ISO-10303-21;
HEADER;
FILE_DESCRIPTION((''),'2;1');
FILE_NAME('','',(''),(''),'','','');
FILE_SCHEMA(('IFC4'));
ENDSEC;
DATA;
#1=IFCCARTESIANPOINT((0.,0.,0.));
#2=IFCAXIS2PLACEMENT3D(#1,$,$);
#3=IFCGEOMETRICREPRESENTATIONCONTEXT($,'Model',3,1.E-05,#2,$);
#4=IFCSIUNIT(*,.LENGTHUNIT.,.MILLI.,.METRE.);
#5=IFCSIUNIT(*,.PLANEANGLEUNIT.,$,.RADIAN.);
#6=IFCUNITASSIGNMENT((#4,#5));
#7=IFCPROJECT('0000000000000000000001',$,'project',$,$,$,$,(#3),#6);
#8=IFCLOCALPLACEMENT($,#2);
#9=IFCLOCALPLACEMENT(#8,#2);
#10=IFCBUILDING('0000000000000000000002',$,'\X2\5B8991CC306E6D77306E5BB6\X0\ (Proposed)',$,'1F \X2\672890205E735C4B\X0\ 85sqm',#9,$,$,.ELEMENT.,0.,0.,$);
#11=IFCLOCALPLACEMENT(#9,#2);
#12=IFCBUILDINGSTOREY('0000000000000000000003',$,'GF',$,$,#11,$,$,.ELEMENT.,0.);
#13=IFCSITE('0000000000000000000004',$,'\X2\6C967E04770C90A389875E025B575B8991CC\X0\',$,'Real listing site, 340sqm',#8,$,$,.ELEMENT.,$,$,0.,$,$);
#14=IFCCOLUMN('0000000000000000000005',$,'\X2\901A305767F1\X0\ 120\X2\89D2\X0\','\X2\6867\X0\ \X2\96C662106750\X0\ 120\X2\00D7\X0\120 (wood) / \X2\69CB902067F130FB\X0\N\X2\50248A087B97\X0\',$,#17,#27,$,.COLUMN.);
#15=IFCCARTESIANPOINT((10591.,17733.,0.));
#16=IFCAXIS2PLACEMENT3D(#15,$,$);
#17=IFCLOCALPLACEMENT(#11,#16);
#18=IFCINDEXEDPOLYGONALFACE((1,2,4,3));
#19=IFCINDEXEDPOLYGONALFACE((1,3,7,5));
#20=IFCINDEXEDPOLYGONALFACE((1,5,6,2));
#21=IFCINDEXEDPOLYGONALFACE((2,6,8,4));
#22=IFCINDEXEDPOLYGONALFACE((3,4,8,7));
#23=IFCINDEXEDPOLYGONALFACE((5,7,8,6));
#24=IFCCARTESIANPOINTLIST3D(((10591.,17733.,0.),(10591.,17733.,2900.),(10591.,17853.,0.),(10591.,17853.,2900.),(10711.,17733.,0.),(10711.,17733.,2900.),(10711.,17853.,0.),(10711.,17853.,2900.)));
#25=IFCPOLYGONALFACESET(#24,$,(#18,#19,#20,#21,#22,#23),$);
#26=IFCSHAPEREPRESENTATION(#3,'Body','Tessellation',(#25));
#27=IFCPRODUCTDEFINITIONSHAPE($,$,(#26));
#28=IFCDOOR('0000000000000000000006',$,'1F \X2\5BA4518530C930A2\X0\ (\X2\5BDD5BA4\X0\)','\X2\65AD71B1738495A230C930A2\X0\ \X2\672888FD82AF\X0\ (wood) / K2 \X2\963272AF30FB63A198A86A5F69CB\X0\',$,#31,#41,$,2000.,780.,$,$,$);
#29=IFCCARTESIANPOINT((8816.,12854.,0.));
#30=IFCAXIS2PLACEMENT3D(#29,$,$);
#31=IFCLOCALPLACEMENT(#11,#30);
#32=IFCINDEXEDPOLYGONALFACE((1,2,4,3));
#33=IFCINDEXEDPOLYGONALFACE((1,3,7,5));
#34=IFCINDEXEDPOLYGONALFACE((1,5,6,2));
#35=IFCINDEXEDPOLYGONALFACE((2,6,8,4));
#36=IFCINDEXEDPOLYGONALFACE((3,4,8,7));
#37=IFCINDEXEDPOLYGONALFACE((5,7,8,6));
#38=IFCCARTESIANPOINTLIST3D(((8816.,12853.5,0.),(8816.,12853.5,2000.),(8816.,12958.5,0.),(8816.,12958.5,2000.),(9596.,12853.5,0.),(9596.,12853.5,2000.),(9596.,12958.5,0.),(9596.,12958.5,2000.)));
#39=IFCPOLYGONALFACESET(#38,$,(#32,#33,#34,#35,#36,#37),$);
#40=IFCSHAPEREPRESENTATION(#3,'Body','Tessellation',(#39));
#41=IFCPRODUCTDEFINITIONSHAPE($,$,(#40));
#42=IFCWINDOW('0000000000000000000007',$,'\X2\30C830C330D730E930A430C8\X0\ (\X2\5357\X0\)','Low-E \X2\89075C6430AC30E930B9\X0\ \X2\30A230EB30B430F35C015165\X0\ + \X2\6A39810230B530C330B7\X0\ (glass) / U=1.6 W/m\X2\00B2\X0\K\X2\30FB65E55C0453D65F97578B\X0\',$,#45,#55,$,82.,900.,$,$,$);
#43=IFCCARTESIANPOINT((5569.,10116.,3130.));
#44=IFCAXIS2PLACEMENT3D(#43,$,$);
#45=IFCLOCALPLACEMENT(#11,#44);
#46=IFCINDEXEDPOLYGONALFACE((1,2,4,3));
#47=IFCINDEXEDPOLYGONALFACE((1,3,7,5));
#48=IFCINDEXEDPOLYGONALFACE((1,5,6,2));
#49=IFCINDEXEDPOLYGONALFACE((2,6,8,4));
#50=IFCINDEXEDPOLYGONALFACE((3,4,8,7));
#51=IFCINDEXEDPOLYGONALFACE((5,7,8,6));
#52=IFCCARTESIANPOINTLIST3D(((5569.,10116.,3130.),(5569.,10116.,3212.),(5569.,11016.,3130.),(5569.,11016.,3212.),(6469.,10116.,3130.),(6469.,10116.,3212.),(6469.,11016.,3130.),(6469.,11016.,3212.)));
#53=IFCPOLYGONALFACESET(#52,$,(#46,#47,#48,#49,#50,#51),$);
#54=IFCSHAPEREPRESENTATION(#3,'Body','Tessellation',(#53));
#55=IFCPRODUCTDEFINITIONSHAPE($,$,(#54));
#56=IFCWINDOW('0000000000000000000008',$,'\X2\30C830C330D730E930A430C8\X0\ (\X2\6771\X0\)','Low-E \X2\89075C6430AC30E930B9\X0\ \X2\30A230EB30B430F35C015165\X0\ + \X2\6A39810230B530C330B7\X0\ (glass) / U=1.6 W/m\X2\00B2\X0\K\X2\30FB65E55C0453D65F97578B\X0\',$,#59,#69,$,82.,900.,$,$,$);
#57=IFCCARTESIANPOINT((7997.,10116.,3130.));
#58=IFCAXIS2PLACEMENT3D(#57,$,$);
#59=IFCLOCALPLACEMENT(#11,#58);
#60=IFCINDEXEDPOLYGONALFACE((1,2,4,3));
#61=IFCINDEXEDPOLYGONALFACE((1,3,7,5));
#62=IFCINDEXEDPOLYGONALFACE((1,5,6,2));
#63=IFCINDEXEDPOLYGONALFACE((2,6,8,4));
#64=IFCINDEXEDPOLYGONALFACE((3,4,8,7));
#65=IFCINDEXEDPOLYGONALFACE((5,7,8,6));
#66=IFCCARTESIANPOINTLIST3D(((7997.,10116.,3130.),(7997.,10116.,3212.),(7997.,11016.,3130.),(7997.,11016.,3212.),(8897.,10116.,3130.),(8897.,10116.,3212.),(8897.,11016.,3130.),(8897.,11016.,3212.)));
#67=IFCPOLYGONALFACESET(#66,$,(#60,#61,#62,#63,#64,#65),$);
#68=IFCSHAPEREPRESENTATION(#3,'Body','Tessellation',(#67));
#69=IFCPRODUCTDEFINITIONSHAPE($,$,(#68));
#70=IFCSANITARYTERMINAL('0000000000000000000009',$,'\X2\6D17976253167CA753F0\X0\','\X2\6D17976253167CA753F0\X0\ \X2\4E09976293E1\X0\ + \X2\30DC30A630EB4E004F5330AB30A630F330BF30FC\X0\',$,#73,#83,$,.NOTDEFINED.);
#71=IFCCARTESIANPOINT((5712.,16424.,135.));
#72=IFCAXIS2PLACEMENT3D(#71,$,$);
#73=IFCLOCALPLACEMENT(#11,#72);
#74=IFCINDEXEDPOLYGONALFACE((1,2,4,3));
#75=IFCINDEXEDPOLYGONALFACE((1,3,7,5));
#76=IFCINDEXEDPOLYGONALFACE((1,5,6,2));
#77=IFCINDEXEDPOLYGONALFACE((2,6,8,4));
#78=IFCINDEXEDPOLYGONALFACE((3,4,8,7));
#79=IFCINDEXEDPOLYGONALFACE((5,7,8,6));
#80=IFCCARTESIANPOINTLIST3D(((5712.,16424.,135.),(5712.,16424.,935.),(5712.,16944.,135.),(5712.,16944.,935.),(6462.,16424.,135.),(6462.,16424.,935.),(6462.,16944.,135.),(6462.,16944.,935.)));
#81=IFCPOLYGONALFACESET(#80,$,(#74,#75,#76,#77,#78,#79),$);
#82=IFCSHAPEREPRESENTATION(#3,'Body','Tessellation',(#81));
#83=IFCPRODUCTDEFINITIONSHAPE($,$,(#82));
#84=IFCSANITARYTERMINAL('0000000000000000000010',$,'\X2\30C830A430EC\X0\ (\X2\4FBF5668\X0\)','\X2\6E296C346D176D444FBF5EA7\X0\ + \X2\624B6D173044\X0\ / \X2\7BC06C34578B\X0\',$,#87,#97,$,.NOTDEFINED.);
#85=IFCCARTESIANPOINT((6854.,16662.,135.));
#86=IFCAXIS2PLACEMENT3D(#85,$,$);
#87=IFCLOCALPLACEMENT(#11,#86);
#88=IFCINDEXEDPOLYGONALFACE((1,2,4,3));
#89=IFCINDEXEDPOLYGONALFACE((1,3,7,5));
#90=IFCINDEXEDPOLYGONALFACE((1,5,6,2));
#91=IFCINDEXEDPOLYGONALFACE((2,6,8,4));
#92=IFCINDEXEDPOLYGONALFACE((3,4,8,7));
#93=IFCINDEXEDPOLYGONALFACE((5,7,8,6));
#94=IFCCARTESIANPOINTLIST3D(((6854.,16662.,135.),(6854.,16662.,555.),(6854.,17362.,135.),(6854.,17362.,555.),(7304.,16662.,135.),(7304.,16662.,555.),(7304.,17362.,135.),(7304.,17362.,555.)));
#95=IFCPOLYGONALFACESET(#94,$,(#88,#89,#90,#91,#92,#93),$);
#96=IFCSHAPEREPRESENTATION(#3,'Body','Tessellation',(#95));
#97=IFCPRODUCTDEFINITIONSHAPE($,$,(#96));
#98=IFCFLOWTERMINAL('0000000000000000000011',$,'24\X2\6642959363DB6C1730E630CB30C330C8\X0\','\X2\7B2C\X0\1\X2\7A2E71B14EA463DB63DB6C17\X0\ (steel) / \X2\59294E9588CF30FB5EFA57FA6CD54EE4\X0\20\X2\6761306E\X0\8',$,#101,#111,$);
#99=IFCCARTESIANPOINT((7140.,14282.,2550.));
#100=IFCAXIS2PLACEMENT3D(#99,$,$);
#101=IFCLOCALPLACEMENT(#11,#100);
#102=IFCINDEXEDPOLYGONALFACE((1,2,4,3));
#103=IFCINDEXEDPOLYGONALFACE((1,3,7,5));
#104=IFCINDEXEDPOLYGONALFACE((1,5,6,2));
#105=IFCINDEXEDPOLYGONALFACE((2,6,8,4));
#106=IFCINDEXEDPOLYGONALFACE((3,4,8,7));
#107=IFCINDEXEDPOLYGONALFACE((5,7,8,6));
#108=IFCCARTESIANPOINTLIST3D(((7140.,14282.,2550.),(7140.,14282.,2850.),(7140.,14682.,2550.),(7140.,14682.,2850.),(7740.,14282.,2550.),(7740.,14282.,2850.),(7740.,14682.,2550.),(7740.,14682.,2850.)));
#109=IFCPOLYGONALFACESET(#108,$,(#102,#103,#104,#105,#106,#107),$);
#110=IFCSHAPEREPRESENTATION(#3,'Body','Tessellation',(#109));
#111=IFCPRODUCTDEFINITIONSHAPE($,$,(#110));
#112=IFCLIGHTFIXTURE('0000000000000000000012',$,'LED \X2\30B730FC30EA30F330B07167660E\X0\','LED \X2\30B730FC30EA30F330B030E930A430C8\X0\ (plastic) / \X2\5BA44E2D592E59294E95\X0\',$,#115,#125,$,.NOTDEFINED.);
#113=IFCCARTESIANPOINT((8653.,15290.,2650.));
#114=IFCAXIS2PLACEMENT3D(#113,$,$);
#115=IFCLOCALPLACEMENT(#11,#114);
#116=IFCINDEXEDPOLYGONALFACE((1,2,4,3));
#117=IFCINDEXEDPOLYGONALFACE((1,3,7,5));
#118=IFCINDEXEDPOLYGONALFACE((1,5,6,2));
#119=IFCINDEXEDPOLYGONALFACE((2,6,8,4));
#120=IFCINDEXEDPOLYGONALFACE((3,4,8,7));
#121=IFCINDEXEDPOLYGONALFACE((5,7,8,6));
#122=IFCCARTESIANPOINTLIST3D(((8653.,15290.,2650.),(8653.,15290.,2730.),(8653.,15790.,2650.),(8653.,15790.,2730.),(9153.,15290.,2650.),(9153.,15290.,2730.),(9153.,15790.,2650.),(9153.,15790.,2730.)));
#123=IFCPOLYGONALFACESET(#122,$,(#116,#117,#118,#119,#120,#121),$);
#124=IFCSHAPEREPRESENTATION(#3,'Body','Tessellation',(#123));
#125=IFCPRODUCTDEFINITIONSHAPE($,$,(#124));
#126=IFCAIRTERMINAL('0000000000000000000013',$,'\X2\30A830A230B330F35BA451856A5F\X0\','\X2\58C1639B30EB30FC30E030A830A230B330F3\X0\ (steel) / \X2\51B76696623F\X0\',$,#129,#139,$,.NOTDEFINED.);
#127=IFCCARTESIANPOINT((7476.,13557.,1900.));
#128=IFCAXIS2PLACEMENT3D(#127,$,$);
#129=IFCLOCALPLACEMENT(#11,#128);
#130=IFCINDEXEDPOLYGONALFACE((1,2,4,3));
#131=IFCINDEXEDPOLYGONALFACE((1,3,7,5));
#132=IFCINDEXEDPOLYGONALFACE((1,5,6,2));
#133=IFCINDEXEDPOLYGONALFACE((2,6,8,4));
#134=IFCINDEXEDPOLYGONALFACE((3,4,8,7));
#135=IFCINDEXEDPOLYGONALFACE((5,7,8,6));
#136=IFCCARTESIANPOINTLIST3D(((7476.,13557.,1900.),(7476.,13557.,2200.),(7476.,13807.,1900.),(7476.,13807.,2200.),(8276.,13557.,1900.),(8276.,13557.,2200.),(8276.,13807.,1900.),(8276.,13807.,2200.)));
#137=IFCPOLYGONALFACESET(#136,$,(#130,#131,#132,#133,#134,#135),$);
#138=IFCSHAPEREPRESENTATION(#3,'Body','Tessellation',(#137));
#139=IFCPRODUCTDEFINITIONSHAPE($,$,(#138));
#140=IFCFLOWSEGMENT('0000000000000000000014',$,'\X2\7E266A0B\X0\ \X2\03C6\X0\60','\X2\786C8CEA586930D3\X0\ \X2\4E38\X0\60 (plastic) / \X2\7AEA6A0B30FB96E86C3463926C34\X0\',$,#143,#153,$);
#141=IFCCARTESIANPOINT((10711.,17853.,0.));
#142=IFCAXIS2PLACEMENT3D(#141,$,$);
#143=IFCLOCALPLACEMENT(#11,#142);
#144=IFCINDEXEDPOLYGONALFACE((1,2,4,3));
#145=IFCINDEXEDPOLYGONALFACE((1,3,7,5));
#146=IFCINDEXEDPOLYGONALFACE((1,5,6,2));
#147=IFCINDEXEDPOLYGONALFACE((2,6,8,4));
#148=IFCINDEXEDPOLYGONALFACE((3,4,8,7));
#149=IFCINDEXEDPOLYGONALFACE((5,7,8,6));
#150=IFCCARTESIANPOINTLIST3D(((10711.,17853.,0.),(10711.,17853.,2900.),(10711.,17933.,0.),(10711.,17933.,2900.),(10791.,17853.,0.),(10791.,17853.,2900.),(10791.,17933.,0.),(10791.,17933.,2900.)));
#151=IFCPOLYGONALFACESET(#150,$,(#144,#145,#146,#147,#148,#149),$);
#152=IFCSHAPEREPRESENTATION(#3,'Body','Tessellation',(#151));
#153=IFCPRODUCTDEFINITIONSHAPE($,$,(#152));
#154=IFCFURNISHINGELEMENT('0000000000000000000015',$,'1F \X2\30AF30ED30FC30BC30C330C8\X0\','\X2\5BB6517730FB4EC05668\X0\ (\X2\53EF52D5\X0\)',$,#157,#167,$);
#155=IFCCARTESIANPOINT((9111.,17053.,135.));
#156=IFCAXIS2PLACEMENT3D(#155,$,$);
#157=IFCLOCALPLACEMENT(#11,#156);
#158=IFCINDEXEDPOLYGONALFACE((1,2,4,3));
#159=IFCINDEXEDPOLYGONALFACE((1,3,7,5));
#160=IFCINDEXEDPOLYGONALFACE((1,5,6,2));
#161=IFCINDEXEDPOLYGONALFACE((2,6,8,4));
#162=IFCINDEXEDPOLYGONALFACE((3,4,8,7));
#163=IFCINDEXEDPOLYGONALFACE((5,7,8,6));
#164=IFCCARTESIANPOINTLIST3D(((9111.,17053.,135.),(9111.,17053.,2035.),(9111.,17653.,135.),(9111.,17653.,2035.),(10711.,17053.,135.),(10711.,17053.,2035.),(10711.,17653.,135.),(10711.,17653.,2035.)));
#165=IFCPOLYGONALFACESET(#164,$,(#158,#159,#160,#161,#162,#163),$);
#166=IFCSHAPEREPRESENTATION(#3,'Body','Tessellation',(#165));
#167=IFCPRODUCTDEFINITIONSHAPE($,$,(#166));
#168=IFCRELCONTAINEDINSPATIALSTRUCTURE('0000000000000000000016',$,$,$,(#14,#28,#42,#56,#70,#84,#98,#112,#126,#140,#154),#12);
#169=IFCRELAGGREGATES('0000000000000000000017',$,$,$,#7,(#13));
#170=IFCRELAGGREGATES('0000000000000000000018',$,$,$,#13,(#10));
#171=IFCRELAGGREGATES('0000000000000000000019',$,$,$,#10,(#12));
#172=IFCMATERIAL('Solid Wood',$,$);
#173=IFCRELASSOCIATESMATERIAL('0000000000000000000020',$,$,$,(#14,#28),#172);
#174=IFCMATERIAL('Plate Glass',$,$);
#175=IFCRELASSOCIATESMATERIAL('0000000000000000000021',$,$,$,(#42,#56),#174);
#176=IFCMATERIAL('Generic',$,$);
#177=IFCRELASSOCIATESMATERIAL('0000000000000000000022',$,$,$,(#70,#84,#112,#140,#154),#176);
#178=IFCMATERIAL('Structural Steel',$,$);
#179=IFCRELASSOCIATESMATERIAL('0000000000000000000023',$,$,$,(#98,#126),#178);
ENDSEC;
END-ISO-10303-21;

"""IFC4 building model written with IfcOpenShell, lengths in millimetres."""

from ifc_helpers import new_model, si_unit, frame, frame_2d, origin, place, context, project, spatial, rectangle, extrude, material, element, save


model = new_model("IFC4")

# Units and contexts
model_context = context("Model", 3, precision=1e-05, world=origin())
ifc_project = project(units=[si_unit("LENGTHUNIT", "METRE", prefix="MILLI"), si_unit("PLANEANGLEUNIT", "RADIAN")], contexts=[model_context])

# Site, building, storey
site_placement = place(None, origin())
site = spatial("IfcSite", under=ifc_project, at=site_placement, Name="沖縄県那覇市字安里", ObjectType="Real listing site, 340sqm", CompositionType="ELEMENT", RefElevation=0.0)
building_placement = place(site_placement, origin())
building = spatial("IfcBuilding", under=site, at=building_placement, Name="安里の海の家 (Proposed)", ObjectType="1F 木造平屋 85sqm", CompositionType="ELEMENT", ElevationOfRefHeight=0.0, ElevationOfTerrain=0.0)
storey_placement = place(building_placement, origin())
storey = spatial("IfcBuildingStorey", under=building, at=storey_placement, Name="GF", CompositionType="ELEMENT", Elevation=0.0)

# Column
ifc_material_1 = material(Name="Solid Wood")
column_1_placement = place(storey_placement, frame((10591.0, 17733.0, 0.0)))
element("IfcColumn", 1, at=column_1_placement, inside=storey, material=ifc_material_1, Name="通し柱 120角", Description="桧 集成材 120×120 (wood) / 構造柱・N値計算", PredefinedType="COLUMN", context=model_context, shape_type="SweptSolid", body=[
    extrude(rectangle(XDim=120.0, YDim=120.0, at=frame_2d((60.0, 60.0))), frame((10591.0, 17733.0, 0.0)), (0.0, 0.0, 1.0), 2900.0),
])

# Door
door_placement = place(storey_placement, frame((8816.0, 12854.0, 0.0)))
element("IfcDoor", 2, at=door_placement, inside=storey, material=ifc_material_1, Name="1F 室内ドア (寝室)", Description="断熱玄関ドア 木製芯 (wood) / K2 防犯・採風機構", OverallHeight=2000.0, OverallWidth=780.0, context=model_context, shape_type="SweptSolid", body=[
    extrude(rectangle(XDim=780.0, YDim=105.0, at=frame_2d((390.0, 52.0))), frame((8816.0, 12854.0, 0.0)), (0.0, 0.0, 1.0), 2000.0),
])

# Windows
ifc_material_2 = material(Name="Plate Glass")
window_1_placement = place(storey_placement, frame((5569.0, 10116.0, 3130.0)))
element("IfcWindow", 3, at=window_1_placement, inside=storey, material=ifc_material_2, Name="トップライト (南)", Description="Low-E 複層ガラス アルゴン封入 + 樹脂サッシ (glass) / U=1.6 W/m²K・日射取得型", OverallHeight=82.0, OverallWidth=900.0, context=model_context, shape_type="SweptSolid", body=[
    extrude(rectangle(XDim=900.0, YDim=900.0, at=frame_2d((450.0, 450.0))), frame((5569.0, 10116.0, 3130.0)), (0.0, 0.0, 1.0), 82.0),
])
window_2_placement = place(storey_placement, frame((7997.0, 10116.0, 3130.0)))
element("IfcWindow", 4, at=window_2_placement, inside=storey, material=ifc_material_2, Name="トップライト (東)", Description="Low-E 複層ガラス アルゴン封入 + 樹脂サッシ (glass) / U=1.6 W/m²K・日射取得型", OverallHeight=82.0, OverallWidth=900.0, context=model_context, shape_type="SweptSolid", body=[
    extrude(rectangle(XDim=900.0, YDim=900.0, at=frame_2d((450.0, 450.0))), frame((7997.0, 10116.0, 3130.0)), (0.0, 0.0, 1.0), 82.0),
])

# Sanitary terminals
ifc_material_3 = material(Name="Generic")
sanitary_terminal_1_placement = place(storey_placement, frame((5712.0, 16424.0, 135.0)))
element("IfcSanitaryTerminal", 5, at=sanitary_terminal_1_placement, inside=storey, material=ifc_material_3, Name="洗面化粧台", Description="洗面化粧台 三面鏡 + ボウル一体カウンター", PredefinedType="NOTDEFINED", context=model_context, shape_type="SweptSolid", body=[
    extrude(rectangle(XDim=750.0, YDim=520.0, at=frame_2d((375.0, 260.0))), frame((5712.0, 16424.0, 135.0)), (0.0, 0.0, 1.0), 800.0),
])
sanitary_terminal_2_placement = place(storey_placement, frame((6854.0, 16662.0, 135.0)))
element("IfcSanitaryTerminal", 6, at=sanitary_terminal_2_placement, inside=storey, material=ifc_material_3, Name="トイレ (便器)", Description="温水洗浄便座 + 手洗い / 節水型", PredefinedType="NOTDEFINED", context=model_context, shape_type="SweptSolid", body=[
    extrude(rectangle(XDim=450.0, YDim=700.0, at=frame_2d((225.0, 350.0))), frame((6854.0, 16662.0, 135.0)), (0.0, 0.0, 1.0), 420.0),
])

# Flow terminal
ifc_material_4 = material(Name="Structural Steel")
flow_terminal_placement = place(storey_placement, frame((7140.0, 14282.0, 2550.0)))
element("IfcFlowTerminal", 7, at=flow_terminal_placement, inside=storey, material=ifc_material_4, Name="24時間換気ユニット", Description="第1種熱交換換気 (steel) / 天井裏・建基法令20条の8", context=model_context, shape_type="SweptSolid", body=[
    extrude(rectangle(XDim=600.0, YDim=400.0, at=frame_2d((300.0, 200.0))), frame((7140.0, 14282.0, 2550.0)), (0.0, 0.0, 1.0), 300.0),
])

# Light fixture
light_fixture_placement = place(storey_placement, frame((8653.0, 15290.0, 2650.0)))
element("IfcLightFixture", 8, at=light_fixture_placement, inside=storey, material=ifc_material_3, Name="LED シーリング照明", Description="LED シーリングライト (plastic) / 室中央天井", PredefinedType="NOTDEFINED", context=model_context, shape_type="SweptSolid", body=[
    extrude(rectangle(XDim=500.0, YDim=500.0, at=frame_2d((250.0, 250.0))), frame((8653.0, 15290.0, 2650.0)), (0.0, 0.0, 1.0), 80.0),
])

# Air terminal
air_terminal_placement = place(storey_placement, frame((7476.0, 13557.0, 1900.0)))
element("IfcAirTerminal", 9, at=air_terminal_placement, inside=storey, material=ifc_material_4, Name="エアコン室内機", Description="壁掛ルームエアコン (steel) / 冷暖房", PredefinedType="NOTDEFINED", context=model_context, shape_type="SweptSolid", body=[
    extrude(rectangle(XDim=800.0, YDim=250.0, at=frame_2d((400.0, 125.0))), frame((7476.0, 13557.0, 1900.0)), (0.0, 0.0, 1.0), 300.0),
])

# Flow segment
flow_segment_placement = place(storey_placement, frame((10711.0, 17853.0, 0.0)))
element("IfcFlowSegment", 10, at=flow_segment_placement, inside=storey, material=ifc_material_3, Name="縦樋 φ60", Description="硬質塩ビ 丸60 (plastic) / 竪樋・雨水排水", context=model_context, shape_type="SweptSolid", body=[
    extrude(rectangle(XDim=80.0, YDim=80.0, at=frame_2d((40.0, 40.0))), frame((10711.0, 17853.0, 0.0)), (0.0, 0.0, 1.0), 2900.0),
])

# Furnishing element
furnishing_placement = place(storey_placement, frame((9111.0, 17053.0, 135.0)))
element("IfcFurnishingElement", 11, at=furnishing_placement, inside=storey, material=ifc_material_3, Name="1F クローゼット", Description="家具・什器 (可動)", context=model_context, shape_type="SweptSolid", body=[
    extrude(rectangle(XDim=1600.0, YDim=600.0, at=frame_2d((800.0, 300.0))), frame((9111.0, 17053.0, 135.0)), (0.0, 0.0, 1.0), 1900.0),
])

save(model, "model.ifc")
